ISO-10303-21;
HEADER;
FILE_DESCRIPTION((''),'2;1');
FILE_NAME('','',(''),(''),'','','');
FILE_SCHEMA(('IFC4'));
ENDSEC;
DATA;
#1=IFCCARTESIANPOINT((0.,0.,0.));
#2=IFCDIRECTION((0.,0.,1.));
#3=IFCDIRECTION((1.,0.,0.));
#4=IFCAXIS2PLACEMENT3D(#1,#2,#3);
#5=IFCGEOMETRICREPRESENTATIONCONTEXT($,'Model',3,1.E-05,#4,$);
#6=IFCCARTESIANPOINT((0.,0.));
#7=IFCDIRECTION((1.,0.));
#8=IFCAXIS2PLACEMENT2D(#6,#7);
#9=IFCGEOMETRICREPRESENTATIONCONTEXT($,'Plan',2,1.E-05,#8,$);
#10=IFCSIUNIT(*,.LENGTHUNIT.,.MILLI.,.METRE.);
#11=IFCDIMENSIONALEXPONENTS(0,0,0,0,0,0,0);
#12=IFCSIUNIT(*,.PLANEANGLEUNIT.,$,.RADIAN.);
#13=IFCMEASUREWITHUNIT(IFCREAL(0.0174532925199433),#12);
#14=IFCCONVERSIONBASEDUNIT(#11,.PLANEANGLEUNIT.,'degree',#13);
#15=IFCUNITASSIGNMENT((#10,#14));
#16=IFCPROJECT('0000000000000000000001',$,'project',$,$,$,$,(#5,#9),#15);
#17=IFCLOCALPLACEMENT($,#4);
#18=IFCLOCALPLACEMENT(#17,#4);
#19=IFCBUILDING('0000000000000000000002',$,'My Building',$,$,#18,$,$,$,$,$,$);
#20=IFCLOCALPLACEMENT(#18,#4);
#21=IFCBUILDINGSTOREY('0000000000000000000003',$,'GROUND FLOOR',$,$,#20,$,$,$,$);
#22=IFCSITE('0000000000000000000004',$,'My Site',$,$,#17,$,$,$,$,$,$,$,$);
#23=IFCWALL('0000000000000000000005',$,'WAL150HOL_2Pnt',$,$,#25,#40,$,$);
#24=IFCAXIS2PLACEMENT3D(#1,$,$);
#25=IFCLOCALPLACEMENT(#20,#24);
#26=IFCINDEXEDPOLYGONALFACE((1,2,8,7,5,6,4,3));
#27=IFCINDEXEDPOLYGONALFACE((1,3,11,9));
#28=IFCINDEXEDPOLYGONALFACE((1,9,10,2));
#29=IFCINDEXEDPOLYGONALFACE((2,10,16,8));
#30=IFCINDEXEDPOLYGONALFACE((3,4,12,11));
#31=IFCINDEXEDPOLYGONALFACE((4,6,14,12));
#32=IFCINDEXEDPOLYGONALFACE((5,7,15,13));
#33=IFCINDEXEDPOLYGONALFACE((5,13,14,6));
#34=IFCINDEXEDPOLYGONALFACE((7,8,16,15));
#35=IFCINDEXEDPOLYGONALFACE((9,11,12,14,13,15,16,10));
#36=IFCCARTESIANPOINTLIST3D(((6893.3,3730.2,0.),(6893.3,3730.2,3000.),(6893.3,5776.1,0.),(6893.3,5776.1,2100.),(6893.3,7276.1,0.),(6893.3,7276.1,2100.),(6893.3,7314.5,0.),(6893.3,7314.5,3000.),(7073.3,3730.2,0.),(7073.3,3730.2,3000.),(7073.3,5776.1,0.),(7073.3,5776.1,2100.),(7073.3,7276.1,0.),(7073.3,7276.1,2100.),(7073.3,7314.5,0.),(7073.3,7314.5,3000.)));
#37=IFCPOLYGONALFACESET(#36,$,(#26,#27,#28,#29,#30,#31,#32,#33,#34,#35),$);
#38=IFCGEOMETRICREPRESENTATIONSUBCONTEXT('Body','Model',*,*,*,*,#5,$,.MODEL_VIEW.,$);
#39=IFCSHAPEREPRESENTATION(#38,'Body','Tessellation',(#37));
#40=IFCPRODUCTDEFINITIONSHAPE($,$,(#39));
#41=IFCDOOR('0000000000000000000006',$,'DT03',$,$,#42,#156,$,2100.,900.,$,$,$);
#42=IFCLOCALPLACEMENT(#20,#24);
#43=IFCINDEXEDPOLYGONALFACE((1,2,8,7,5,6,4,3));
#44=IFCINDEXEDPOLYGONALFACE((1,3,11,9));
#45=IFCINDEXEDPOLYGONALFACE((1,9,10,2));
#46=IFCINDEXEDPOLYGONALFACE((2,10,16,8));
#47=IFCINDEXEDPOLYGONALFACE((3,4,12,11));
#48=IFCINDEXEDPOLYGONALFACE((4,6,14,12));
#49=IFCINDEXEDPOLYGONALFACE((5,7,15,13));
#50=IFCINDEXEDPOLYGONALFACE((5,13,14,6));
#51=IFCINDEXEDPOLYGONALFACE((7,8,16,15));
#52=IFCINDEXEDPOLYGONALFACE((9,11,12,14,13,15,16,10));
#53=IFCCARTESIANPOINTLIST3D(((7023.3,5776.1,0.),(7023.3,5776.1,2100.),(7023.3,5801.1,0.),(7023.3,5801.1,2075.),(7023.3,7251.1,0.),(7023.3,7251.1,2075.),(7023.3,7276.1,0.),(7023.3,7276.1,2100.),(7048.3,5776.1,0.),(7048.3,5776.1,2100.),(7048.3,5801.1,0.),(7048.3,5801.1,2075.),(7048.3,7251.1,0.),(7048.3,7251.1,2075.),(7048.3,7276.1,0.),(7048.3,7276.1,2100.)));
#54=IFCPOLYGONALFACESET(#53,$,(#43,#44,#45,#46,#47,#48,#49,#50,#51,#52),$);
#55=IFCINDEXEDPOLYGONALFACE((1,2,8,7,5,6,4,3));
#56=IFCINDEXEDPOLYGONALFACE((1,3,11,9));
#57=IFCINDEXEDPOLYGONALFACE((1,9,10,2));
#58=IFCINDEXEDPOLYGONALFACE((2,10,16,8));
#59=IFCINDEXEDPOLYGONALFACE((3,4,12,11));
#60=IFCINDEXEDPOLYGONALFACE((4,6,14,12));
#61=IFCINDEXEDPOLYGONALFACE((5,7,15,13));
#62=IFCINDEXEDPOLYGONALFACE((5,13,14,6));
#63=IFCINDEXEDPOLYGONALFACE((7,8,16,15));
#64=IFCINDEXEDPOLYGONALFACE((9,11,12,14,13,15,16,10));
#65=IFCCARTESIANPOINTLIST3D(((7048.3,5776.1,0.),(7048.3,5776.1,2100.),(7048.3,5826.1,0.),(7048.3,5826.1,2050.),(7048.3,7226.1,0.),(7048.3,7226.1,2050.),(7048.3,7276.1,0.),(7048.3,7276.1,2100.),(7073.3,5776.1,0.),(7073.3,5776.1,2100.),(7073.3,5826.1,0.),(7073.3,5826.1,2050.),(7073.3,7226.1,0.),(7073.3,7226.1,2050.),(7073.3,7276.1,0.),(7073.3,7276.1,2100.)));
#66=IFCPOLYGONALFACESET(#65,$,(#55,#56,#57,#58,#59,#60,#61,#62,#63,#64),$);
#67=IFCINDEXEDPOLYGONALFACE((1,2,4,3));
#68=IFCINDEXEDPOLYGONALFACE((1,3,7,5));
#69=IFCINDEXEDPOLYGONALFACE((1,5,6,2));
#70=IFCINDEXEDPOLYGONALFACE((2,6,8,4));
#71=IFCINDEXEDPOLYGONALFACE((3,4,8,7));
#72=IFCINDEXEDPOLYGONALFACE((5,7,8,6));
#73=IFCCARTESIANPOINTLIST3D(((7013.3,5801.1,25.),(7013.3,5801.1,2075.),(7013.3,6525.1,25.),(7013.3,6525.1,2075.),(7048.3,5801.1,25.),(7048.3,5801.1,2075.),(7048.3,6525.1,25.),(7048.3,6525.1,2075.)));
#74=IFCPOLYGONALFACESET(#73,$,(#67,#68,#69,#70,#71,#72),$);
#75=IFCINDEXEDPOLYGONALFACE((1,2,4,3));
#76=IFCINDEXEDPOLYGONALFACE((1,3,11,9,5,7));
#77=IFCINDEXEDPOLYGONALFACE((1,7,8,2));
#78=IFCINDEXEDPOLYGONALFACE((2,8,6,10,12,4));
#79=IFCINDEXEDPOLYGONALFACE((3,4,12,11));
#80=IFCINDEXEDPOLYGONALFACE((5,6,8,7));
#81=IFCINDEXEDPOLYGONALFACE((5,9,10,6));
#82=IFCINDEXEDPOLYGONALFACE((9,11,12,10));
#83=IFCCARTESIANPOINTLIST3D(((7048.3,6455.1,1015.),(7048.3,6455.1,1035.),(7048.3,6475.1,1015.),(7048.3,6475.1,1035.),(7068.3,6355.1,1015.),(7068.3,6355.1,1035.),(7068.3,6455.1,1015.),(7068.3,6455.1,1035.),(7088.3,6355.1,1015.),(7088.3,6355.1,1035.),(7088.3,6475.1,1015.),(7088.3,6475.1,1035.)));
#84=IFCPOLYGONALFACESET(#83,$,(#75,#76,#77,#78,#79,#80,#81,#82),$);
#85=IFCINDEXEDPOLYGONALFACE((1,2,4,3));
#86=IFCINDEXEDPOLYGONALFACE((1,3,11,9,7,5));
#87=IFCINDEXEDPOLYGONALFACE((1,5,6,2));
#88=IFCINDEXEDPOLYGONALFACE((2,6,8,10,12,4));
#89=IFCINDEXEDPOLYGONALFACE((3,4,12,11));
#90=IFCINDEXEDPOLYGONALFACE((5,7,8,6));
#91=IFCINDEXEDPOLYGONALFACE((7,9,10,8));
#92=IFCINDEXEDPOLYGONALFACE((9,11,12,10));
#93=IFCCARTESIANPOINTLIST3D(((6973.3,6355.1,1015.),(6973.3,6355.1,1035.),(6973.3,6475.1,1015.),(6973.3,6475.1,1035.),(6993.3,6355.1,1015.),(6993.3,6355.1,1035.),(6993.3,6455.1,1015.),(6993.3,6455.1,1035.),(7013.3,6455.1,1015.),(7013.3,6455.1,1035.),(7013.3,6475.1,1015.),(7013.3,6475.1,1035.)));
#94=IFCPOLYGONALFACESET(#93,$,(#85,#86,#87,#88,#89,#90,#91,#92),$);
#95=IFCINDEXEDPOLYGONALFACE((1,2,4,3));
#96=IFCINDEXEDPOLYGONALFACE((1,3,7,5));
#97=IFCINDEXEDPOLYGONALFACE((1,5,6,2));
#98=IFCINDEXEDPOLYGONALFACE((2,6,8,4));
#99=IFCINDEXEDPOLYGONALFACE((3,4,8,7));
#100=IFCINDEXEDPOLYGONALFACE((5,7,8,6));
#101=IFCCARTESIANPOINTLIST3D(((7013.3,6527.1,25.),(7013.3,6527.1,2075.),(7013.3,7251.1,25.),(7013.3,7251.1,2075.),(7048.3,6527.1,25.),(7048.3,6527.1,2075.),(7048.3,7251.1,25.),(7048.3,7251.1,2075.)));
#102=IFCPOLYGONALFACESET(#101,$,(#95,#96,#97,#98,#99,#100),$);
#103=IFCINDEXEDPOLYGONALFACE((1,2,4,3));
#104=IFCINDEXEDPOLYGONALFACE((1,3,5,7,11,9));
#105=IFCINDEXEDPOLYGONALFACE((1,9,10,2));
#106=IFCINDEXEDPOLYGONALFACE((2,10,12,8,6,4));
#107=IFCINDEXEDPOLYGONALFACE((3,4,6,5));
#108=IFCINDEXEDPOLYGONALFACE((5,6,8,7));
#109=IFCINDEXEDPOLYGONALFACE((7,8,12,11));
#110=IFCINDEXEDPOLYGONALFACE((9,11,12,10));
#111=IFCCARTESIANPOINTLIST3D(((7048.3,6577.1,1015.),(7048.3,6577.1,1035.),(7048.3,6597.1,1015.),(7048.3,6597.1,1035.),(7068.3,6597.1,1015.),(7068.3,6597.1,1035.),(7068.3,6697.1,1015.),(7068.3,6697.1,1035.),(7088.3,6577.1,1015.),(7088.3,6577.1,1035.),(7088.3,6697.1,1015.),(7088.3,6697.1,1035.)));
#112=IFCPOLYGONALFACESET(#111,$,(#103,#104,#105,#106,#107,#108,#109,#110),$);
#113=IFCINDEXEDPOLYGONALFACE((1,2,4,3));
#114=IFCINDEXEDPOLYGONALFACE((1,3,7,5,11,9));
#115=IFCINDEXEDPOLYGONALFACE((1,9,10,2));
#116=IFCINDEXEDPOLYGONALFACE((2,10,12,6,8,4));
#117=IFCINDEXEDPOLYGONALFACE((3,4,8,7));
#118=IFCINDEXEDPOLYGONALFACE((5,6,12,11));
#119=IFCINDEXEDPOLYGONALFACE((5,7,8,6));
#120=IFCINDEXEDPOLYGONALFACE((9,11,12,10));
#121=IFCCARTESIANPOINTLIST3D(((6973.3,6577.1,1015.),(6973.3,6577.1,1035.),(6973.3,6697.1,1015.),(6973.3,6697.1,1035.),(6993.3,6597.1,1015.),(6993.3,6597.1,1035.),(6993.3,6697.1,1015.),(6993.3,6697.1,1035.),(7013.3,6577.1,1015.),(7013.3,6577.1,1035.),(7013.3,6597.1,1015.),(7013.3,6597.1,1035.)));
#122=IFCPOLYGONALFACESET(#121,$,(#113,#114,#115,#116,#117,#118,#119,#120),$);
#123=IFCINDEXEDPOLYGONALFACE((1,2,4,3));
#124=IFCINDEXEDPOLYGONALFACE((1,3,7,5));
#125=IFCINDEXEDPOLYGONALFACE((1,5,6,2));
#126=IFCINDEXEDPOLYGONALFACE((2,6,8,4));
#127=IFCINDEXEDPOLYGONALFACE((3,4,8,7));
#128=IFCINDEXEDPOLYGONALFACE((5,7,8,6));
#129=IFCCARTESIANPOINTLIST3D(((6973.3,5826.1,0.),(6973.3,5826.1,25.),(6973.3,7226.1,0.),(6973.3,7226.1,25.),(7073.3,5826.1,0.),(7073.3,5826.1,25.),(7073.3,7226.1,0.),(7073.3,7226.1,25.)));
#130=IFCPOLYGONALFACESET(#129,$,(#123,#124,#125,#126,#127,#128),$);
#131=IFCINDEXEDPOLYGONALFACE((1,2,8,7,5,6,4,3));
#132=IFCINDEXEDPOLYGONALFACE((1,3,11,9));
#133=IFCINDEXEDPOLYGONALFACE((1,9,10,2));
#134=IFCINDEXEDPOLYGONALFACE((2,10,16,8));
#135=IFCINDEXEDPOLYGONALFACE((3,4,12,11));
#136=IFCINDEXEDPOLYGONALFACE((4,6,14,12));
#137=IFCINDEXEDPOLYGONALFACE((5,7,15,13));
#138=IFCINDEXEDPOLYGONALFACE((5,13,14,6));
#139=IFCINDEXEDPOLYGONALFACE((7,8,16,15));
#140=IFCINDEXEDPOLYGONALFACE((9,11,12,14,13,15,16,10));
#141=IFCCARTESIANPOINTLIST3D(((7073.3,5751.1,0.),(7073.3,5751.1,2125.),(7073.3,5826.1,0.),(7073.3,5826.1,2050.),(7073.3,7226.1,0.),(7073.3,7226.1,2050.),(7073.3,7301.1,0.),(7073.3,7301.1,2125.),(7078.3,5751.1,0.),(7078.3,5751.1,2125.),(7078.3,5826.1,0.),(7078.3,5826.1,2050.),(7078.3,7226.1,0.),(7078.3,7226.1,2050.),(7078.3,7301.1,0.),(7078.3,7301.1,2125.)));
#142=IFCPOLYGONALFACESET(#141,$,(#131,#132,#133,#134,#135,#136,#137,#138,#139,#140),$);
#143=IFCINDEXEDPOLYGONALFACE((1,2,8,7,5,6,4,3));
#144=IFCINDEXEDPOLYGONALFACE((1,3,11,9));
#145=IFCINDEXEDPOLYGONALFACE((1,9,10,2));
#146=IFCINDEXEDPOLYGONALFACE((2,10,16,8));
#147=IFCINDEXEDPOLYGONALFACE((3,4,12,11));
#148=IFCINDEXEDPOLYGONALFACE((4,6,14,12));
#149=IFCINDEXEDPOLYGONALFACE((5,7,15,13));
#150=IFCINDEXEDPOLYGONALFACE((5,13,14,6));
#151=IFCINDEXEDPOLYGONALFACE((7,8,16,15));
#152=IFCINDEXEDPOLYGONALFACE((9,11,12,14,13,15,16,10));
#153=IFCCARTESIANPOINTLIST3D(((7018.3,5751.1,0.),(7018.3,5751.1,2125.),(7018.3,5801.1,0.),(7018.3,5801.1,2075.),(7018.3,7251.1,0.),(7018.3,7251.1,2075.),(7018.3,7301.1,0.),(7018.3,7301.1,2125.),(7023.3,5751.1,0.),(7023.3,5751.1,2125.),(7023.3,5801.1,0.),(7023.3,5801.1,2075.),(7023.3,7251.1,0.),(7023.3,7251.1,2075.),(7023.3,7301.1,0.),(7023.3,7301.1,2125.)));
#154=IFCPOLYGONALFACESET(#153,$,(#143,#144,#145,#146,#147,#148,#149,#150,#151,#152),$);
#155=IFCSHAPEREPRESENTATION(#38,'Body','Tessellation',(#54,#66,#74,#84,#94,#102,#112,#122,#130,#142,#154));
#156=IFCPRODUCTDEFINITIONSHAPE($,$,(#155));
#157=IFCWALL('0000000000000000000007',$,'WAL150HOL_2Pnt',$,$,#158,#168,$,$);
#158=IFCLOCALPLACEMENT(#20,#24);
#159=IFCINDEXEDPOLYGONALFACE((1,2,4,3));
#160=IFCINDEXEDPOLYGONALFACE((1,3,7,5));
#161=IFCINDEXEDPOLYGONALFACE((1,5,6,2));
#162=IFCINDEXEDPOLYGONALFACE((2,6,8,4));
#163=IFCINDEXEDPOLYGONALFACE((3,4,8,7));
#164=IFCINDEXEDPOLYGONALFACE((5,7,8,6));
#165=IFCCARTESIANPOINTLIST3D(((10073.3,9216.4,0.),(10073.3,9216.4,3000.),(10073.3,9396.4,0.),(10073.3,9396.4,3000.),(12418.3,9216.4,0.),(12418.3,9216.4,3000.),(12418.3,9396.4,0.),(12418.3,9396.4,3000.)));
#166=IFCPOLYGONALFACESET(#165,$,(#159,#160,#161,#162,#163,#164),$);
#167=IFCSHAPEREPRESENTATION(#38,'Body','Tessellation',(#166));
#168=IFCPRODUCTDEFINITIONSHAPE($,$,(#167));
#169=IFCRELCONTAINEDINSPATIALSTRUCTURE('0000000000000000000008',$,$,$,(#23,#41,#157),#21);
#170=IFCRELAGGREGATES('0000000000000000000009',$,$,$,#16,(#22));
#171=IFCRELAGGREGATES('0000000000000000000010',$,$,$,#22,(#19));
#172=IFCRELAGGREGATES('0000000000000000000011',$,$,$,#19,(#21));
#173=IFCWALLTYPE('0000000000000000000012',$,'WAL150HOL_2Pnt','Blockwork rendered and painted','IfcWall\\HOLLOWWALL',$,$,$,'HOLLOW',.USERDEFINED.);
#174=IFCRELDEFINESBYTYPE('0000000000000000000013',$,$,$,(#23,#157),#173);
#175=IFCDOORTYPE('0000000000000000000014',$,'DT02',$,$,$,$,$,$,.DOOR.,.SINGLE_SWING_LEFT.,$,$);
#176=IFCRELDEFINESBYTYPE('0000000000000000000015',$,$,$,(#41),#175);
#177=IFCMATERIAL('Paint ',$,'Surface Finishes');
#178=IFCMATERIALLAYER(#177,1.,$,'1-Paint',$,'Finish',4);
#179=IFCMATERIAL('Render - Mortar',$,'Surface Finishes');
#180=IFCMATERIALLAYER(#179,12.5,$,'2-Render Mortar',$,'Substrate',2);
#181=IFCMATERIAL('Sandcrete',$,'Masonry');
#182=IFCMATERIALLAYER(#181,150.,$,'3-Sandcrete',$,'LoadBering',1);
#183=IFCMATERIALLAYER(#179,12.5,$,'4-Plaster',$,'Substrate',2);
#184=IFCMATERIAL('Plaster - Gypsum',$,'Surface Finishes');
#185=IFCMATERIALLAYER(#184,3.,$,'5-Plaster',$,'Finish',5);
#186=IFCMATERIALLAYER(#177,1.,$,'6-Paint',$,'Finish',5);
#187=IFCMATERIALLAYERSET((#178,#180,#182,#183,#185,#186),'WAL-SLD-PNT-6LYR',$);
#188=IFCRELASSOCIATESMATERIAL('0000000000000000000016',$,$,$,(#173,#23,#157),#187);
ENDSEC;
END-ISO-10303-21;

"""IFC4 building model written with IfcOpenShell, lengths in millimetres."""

from ifc_helpers import new_model, entity, si_unit, converted_unit, frame, origin_with_axes, origin_2d_with_axis, place, context, subcontext, project, spatial, line, indexed_curve, outline, extrude, shape, source, transform, mapped, material, layer, layer_set, layer_usage, type_object, type_shapes, element, fill, save


model = new_model("IFC4")

# Units and contexts
model_context = context("Model", 3, precision=1e-05, world=origin_with_axes())
plan_context = context("Plan", 2, precision=1e-05, world=origin_2d_with_axis())
body_context_1 = subcontext(model_context, "Body", "Model", "MODEL_VIEW")
body_context_2 = subcontext(plan_context, "Body", "Plan", "PLAN_VIEW")
ifc_project = project(units=[si_unit("LENGTHUNIT", "METRE", prefix="MILLI"), converted_unit("PLANEANGLEUNIT", "degree", entity("IfcReal", 0.0174532925199433), si_unit("PLANEANGLEUNIT", "RADIAN"), dimensions=[0, 0, 0, 0, 0, 0, 0])], contexts=[model_context, plan_context])

# Site, building, storey
site_placement = place(None, origin_with_axes())
site = spatial("IfcSite", under=ifc_project, at=site_placement, Name="My Site")
building_placement = place(site_placement, origin_with_axes())
building = spatial("IfcBuilding", under=site, at=building_placement, Name="My Building")
storey_placement = place(building_placement, origin_with_axes())
storey = spatial("IfcBuildingStorey", under=building, at=storey_placement, Name="GROUND FLOOR")

# Shared definitions
ifc_material_1 = material(Name="Paint ", Category="Surface Finishes")
ifc_layer_1 = layer(ifc_material_1, 1.0, Name="1-Paint", Category="Finish", Priority=4)
ifc_material_2 = material(Name="Render - Mortar", Category="Surface Finishes")
ifc_layer_2 = layer(ifc_material_2, 12.5, Name="2-Render Mortar", Category="Substrate", Priority=2)
ifc_material_3 = material(Name="Sandcrete", Category="Masonry")
ifc_layer_3 = layer(ifc_material_3, 150.0, Name="3-Sandcrete", Category="LoadBering", Priority=1)
ifc_layer_4 = layer(ifc_material_2, 12.5, Name="4-Plaster", Category="Substrate", Priority=2)
ifc_material_4 = material(Name="Plaster - Gypsum", Category="Surface Finishes")
ifc_layer_5 = layer(ifc_material_4, 3.0, Name="5-Plaster", Category="Finish", Priority=5)
ifc_layer_6 = layer(ifc_material_1, 1.0, Name="6-Paint", Category="Finish", Priority=5)
ifc_layer_set_1 = layer_set([ifc_layer_1, ifc_layer_2, ifc_layer_3, ifc_layer_4, ifc_layer_5, ifc_layer_6], Name="WAL-SLD-PNT-6LYR")
wall_type_1 = type_object("IfcWallType", Name="WAL150HOL_2Pnt", Description="Blockwork rendered and painted", ApplicableOccurrence="IfcWall\\HOLLOWWALL", ElementType="HOLLOW", PredefinedType="USERDEFINED", material=ifc_layer_set_1)

# Wall, opening, door
ifc_layer_usage_1 = layer_usage(ifc_layer_set_1, "AXIS2", "POSITIVE", 0.0)
wall_1_placement = place(storey_placement, frame((7073.3, 3730.2, 0.0), z_axis=(0.0, 0.0, 1.0), x_axis=(0.000002, 1.0, 0.0)))
wall_1 = element("IfcWall", 1, at=wall_1_placement, inside=storey, type_object=wall_type_1, material=ifc_layer_usage_1, Name="WAL150HOL_2Pnt", context=body_context_1, shape_type="SweptSolid", body=[
    extrude(outline(indexed_curve([(0.0, 0.0), (0.0, 180.0), (3584.3, 180.0), (3584.3, 0.0), (0.0, 0.0)], self_intersect=False)), origin_with_axes(), (0.0, 0.0, 1.0), 3000.0),
])
shared_shape_1 = source(origin_with_axes(), body_context_1, "Body", "SweptSolid", [
    extrude(outline(indexed_curve([(0.0, 0.0), (1500.0, 0.0), (1500.0, 2100.0), (0.0, 2100.0)], segments=[line(1, 2, 3, 4, 1)])), frame((0.0, -600.0, 0.0), z_axis=(0.0, -1.0, 0.0), x_axis=(1.0, 0.0, 0.0)), (0.0, 0.0, -1.0), 1200.0),
])
opening_1_placement = place(wall_1_placement, frame((3546.0, 85.0, 0.0), z_axis=(0.0, 0.0, 1.0), x_axis=(-1.0, 0.0, 0.0)))
opening_1 = element("IfcOpeningElement", 2, at=opening_1_placement, cuts=wall_1, PredefinedType="OPENING", context=body_context_1, shape_type="MappedRepresentation", body=[
    mapped(shared_shape_1, transform((0.0, 0.0, 0.0), x_axis=(1.0, 0.0, 0.0), y_axis=(0.0, 1.0, 0.0), z_axis=(0.0, 0.0, 1.0), scale=1.0)),
])
door_type_1 = type_object("IfcDoorType", Name="DT02", OperationType="SINGLE_SWING_LEFT", PredefinedType="DOOR")
shared_shape_2 = source(origin_with_axes(), body_context_1, "Body", "SweptSolid", [
    extrude(outline(indexed_curve([(0.0, 0.0), (0.0, 2100.0), (1500.0, 2100.0), (1500.0, 0.0), (1475.0, 0.0), (1475.0, 2075.0), (25.0, 2075.0), (25.0, 0.0)], segments=[line(1, 2, 3, 4, 5, 6, 7, 8, 1)])), frame((0.0, 25.0, 0.0), z_axis=(0.0, -1.0, 0.0), x_axis=(1.0, 0.0, 0.0)), (0.0, 0.0, -1.0), 25.0),
    extrude(outline(indexed_curve([(0.0, 0.0), (0.0, 2100.0), (1500.0, 2100.0), (1500.0, 0.0), (1450.0, 0.0), (1450.0, 2050.0), (50.0, 2050.0), (50.0, 0.0)], segments=[line(1, 2, 3, 4, 5, 6, 7, 8, 1)])), frame((0.0, 0.0, 0.0), z_axis=(0.0, -1.0, 0.0), x_axis=(1.0, 0.0, 0.0)), (0.0, 0.0, -1.0), 25.0),
    extrude(outline(indexed_curve([(0.0, 0.0), (724.0, 0.0), (724.0, 35.0), (0.0, 35.0)], segments=[line(1, 2, 3, 4, 1)])), frame((25.0, 25.0, 25.0), z_axis=(0.0, 0.0, 1.0), x_axis=(1.0, 0.0, 0.0)), (0.0, 0.0, 1.0), 2050.0),
    extrude(outline(indexed_curve([(0.0, 0.0), (0.0, -40.0), (-120.0, -40.0), (-120.0, -20.0), (-20.0, -20.0), (-20.0, 0.0)], segments=[line(1, 2, 3, 4, 5, 6, 1)])), frame((699.0, 25.0, 1015.0), z_axis=(0.0, 0.0, 1.0), x_axis=(1.0, 0.0, 0.0)), (0.0, 0.0, 1.0), 20.0),
    extrude(outline(indexed_curve([(0.0, 0.0), (0.0, 40.0), (-120.0, 40.0), (-120.0, 20.0), (-20.0, 20.0), (-20.0, 0.0)], segments=[line(1, 2, 3, 4, 5, 6, 1)])), frame((699.0, 60.0, 1015.0), z_axis=(0.0, 0.0, 1.0), x_axis=(1.0, 0.0, 0.0)), (0.0, 0.0, 1.0), 20.0),
    extrude(outline(indexed_curve([(0.0, 0.0), (-724.0, 0.0), (-724.0, 35.0), (0.0, 35.0)], segments=[line(1, 2, 3, 4, 1)])), frame((1475.0, 25.0, 25.0), z_axis=(0.0, 0.0, 1.0), x_axis=(1.0, 0.0, 0.0)), (0.0, 0.0, 1.0), 2050.0),
    extrude(outline(indexed_curve([(0.0, 0.0), (0.0, -40.0), (120.0, -40.0), (120.0, -20.0), (20.0, -20.0), (20.0, 0.0)], segments=[line(1, 2, 3, 4, 5, 6, 1)])), frame((801.0, 25.0, 1015.0), z_axis=(0.0, 0.0, 1.0), x_axis=(1.0, 0.0, 0.0)), (0.0, 0.0, 1.0), 20.0),
    extrude(outline(indexed_curve([(0.0, 0.0), (0.0, 40.0), (120.0, 40.0), (120.0, 20.0), (20.0, 20.0), (20.0, 0.0)], segments=[line(1, 2, 3, 4, 5, 6, 1)])), frame((801.0, 60.0, 1015.0), z_axis=(0.0, 0.0, 1.0), x_axis=(1.0, 0.0, 0.0)), (0.0, 0.0, 1.0), 20.0),
    extrude(outline(indexed_curve([(0.0, 0.0), (1400.0, 0.0), (1400.0, 100.0), (0.0, 100.0)], segments=[line(1, 2, 3, 4, 1)])), frame((50.0, 0.0, 0.0), z_axis=(0.0, 0.0, 1.0), x_axis=(1.0, 0.0, 0.0)), (0.0, 0.0, 1.0), 25.0),
    extrude(outline(indexed_curve([(0.0, 0.0), (0.0, 2125.0), (1550.0, 2125.0), (1550.0, 0.0), (1475.0, 0.0), (1475.0, 2050.0), (75.0, 2050.0), (75.0, 0.0)], segments=[line(1, 2, 3, 4, 5, 6, 7, 8, 1)])), frame((-25.0, -5.0, 0.0), z_axis=(0.0, -1.0, 0.0), x_axis=(1.0, 0.0, 0.0)), (0.0, 0.0, -1.0), 5.0),
    extrude(outline(indexed_curve([(0.0, 0.0), (0.0, 2125.0), (1550.0, 2125.0), (1550.0, 0.0), (1500.0, 0.0), (1500.0, 2075.0), (50.0, 2075.0), (50.0, 0.0)], segments=[line(1, 2, 3, 4, 5, 6, 7, 8, 1)])), frame((-25.0, 50.0, 0.0), z_axis=(0.0, -1.0, 0.0), x_axis=(1.0, 0.0, 0.0)), (0.0, 0.0, -1.0), 5.0),
])
shared_shape_3 = source(origin_with_axes(), body_context_2, "Body", "Curve2D", [
    entity("IfcIndexedPolyCurve", entity("IfcCartesianPointList2D", [[0.0, 0.0], [0.0, 50.0], [25.0, 50.0], [25.0, 25.0], [50.0, 25.0], [50.0, 0.0]]), [entity("IfcLineIndex", [1, 2, 3, 4, 5, 6, 1])]),
    entity("IfcIndexedPolyCurve", entity("IfcCartesianPointList2D", [[1500.0, 0.0], [1500.0, 50.0], [1475.0, 50.0], [1475.0, 25.0], [1450.0, 25.0], [1450.0, 0.0]]), [entity("IfcLineIndex", [1, 2, 3, 4, 5, 6, 1])]),
    entity("IfcTrimmedCurve", entity("IfcEllipse", entity("IfcAxis2Placement2D", entity("IfcCartesianPoint", [60.0, 50.0]), entity("IfcDirection", [1.0, 0.0])), 690.0, 725.0), [entity("IfcCartesianPoint", [750.0, 50.0])], [entity("IfcCartesianPoint", [60.0, 775.0])], True, "CARTESIAN"),
    entity("IfcIndexedPolyCurve", entity("IfcCartesianPointList2D", [[25.0, 50.0], [60.0, 50.0], [60.0, 775.0], [25.0, 775.0]]), [entity("IfcLineIndex", [1, 2, 3, 4, 1])]),
    entity("IfcTrimmedCurve", entity("IfcEllipse", entity("IfcAxis2Placement2D", entity("IfcCartesianPoint", [1440.0, 50.0]), entity("IfcDirection", [1.0, 0.0])), 690.0, 725.0), [entity("IfcCartesianPoint", [1440.0, 775.0])], [entity("IfcCartesianPoint", [750.0, 50.0])], True, "CARTESIAN"),
    entity("IfcIndexedPolyCurve", entity("IfcCartesianPointList2D", [[1475.0, 50.0], [1440.0, 50.0], [1440.0, 775.0], [1475.0, 775.0]]), [entity("IfcLineIndex", [1, 2, 3, 4, 1])]),
])
type_shapes(door_type_1, [shared_shape_2, shared_shape_3])
door_1_placement = place(opening_1_placement, frame((1500.0, 85.0, 0.0), z_axis=(0.0, 0.0, 1.0), x_axis=(-1.0, 0.0, 0.0)))
door_1 = element("IfcDoor", 3, at=door_1_placement, inside=storey, type_object=door_type_1, Name="DT03", OverallHeight=2100.0, OverallWidth=900.0, shapes=[
    shape(body_context_1, "Body", "MappedRepresentation", [mapped(shared_shape_2, transform((0.0, 0.0, 0.0), x_axis=(1.0, 0.0, 0.0), y_axis=(0.0, 1.0, 0.0), z_axis=(0.0, 0.0, 1.0), scale=1.0))]),
    shape(body_context_2, "Body", "MappedRepresentation", [mapped(shared_shape_3, transform((0.0, 0.0, 0.0), x_axis=(1.0, 0.0, 0.0), y_axis=(0.0, 1.0, 0.0), z_axis=(0.0, 0.0, 1.0), scale=1.0))]),
])
fill(opening_1, door_1)

# Wall
ifc_layer_usage_2 = layer_usage(ifc_layer_set_1, "AXIS2", "POSITIVE", 0.0)
wall_2_placement = place(storey_placement, frame((10073.3, 9216.4, 0.0), z_axis=(0.0, 0.0, 1.0), x_axis=(1.0, -0.000001, 0.0)))
element("IfcWall", 4, at=wall_2_placement, inside=storey, type_object=wall_type_1, material=ifc_layer_usage_2, Name="WAL150HOL_2Pnt", context=body_context_1, shape_type="SweptSolid", body=[
    extrude(outline(indexed_curve([(0.0, 0.0), (0.0, 180.0), (2345.0, 180.0), (2345.0, 0.0), (0.0, 0.0)], self_intersect=False)), origin_with_axes(), (0.0, 0.0, 1.0), 3000.0),
])

save(model, "model.ifc")
